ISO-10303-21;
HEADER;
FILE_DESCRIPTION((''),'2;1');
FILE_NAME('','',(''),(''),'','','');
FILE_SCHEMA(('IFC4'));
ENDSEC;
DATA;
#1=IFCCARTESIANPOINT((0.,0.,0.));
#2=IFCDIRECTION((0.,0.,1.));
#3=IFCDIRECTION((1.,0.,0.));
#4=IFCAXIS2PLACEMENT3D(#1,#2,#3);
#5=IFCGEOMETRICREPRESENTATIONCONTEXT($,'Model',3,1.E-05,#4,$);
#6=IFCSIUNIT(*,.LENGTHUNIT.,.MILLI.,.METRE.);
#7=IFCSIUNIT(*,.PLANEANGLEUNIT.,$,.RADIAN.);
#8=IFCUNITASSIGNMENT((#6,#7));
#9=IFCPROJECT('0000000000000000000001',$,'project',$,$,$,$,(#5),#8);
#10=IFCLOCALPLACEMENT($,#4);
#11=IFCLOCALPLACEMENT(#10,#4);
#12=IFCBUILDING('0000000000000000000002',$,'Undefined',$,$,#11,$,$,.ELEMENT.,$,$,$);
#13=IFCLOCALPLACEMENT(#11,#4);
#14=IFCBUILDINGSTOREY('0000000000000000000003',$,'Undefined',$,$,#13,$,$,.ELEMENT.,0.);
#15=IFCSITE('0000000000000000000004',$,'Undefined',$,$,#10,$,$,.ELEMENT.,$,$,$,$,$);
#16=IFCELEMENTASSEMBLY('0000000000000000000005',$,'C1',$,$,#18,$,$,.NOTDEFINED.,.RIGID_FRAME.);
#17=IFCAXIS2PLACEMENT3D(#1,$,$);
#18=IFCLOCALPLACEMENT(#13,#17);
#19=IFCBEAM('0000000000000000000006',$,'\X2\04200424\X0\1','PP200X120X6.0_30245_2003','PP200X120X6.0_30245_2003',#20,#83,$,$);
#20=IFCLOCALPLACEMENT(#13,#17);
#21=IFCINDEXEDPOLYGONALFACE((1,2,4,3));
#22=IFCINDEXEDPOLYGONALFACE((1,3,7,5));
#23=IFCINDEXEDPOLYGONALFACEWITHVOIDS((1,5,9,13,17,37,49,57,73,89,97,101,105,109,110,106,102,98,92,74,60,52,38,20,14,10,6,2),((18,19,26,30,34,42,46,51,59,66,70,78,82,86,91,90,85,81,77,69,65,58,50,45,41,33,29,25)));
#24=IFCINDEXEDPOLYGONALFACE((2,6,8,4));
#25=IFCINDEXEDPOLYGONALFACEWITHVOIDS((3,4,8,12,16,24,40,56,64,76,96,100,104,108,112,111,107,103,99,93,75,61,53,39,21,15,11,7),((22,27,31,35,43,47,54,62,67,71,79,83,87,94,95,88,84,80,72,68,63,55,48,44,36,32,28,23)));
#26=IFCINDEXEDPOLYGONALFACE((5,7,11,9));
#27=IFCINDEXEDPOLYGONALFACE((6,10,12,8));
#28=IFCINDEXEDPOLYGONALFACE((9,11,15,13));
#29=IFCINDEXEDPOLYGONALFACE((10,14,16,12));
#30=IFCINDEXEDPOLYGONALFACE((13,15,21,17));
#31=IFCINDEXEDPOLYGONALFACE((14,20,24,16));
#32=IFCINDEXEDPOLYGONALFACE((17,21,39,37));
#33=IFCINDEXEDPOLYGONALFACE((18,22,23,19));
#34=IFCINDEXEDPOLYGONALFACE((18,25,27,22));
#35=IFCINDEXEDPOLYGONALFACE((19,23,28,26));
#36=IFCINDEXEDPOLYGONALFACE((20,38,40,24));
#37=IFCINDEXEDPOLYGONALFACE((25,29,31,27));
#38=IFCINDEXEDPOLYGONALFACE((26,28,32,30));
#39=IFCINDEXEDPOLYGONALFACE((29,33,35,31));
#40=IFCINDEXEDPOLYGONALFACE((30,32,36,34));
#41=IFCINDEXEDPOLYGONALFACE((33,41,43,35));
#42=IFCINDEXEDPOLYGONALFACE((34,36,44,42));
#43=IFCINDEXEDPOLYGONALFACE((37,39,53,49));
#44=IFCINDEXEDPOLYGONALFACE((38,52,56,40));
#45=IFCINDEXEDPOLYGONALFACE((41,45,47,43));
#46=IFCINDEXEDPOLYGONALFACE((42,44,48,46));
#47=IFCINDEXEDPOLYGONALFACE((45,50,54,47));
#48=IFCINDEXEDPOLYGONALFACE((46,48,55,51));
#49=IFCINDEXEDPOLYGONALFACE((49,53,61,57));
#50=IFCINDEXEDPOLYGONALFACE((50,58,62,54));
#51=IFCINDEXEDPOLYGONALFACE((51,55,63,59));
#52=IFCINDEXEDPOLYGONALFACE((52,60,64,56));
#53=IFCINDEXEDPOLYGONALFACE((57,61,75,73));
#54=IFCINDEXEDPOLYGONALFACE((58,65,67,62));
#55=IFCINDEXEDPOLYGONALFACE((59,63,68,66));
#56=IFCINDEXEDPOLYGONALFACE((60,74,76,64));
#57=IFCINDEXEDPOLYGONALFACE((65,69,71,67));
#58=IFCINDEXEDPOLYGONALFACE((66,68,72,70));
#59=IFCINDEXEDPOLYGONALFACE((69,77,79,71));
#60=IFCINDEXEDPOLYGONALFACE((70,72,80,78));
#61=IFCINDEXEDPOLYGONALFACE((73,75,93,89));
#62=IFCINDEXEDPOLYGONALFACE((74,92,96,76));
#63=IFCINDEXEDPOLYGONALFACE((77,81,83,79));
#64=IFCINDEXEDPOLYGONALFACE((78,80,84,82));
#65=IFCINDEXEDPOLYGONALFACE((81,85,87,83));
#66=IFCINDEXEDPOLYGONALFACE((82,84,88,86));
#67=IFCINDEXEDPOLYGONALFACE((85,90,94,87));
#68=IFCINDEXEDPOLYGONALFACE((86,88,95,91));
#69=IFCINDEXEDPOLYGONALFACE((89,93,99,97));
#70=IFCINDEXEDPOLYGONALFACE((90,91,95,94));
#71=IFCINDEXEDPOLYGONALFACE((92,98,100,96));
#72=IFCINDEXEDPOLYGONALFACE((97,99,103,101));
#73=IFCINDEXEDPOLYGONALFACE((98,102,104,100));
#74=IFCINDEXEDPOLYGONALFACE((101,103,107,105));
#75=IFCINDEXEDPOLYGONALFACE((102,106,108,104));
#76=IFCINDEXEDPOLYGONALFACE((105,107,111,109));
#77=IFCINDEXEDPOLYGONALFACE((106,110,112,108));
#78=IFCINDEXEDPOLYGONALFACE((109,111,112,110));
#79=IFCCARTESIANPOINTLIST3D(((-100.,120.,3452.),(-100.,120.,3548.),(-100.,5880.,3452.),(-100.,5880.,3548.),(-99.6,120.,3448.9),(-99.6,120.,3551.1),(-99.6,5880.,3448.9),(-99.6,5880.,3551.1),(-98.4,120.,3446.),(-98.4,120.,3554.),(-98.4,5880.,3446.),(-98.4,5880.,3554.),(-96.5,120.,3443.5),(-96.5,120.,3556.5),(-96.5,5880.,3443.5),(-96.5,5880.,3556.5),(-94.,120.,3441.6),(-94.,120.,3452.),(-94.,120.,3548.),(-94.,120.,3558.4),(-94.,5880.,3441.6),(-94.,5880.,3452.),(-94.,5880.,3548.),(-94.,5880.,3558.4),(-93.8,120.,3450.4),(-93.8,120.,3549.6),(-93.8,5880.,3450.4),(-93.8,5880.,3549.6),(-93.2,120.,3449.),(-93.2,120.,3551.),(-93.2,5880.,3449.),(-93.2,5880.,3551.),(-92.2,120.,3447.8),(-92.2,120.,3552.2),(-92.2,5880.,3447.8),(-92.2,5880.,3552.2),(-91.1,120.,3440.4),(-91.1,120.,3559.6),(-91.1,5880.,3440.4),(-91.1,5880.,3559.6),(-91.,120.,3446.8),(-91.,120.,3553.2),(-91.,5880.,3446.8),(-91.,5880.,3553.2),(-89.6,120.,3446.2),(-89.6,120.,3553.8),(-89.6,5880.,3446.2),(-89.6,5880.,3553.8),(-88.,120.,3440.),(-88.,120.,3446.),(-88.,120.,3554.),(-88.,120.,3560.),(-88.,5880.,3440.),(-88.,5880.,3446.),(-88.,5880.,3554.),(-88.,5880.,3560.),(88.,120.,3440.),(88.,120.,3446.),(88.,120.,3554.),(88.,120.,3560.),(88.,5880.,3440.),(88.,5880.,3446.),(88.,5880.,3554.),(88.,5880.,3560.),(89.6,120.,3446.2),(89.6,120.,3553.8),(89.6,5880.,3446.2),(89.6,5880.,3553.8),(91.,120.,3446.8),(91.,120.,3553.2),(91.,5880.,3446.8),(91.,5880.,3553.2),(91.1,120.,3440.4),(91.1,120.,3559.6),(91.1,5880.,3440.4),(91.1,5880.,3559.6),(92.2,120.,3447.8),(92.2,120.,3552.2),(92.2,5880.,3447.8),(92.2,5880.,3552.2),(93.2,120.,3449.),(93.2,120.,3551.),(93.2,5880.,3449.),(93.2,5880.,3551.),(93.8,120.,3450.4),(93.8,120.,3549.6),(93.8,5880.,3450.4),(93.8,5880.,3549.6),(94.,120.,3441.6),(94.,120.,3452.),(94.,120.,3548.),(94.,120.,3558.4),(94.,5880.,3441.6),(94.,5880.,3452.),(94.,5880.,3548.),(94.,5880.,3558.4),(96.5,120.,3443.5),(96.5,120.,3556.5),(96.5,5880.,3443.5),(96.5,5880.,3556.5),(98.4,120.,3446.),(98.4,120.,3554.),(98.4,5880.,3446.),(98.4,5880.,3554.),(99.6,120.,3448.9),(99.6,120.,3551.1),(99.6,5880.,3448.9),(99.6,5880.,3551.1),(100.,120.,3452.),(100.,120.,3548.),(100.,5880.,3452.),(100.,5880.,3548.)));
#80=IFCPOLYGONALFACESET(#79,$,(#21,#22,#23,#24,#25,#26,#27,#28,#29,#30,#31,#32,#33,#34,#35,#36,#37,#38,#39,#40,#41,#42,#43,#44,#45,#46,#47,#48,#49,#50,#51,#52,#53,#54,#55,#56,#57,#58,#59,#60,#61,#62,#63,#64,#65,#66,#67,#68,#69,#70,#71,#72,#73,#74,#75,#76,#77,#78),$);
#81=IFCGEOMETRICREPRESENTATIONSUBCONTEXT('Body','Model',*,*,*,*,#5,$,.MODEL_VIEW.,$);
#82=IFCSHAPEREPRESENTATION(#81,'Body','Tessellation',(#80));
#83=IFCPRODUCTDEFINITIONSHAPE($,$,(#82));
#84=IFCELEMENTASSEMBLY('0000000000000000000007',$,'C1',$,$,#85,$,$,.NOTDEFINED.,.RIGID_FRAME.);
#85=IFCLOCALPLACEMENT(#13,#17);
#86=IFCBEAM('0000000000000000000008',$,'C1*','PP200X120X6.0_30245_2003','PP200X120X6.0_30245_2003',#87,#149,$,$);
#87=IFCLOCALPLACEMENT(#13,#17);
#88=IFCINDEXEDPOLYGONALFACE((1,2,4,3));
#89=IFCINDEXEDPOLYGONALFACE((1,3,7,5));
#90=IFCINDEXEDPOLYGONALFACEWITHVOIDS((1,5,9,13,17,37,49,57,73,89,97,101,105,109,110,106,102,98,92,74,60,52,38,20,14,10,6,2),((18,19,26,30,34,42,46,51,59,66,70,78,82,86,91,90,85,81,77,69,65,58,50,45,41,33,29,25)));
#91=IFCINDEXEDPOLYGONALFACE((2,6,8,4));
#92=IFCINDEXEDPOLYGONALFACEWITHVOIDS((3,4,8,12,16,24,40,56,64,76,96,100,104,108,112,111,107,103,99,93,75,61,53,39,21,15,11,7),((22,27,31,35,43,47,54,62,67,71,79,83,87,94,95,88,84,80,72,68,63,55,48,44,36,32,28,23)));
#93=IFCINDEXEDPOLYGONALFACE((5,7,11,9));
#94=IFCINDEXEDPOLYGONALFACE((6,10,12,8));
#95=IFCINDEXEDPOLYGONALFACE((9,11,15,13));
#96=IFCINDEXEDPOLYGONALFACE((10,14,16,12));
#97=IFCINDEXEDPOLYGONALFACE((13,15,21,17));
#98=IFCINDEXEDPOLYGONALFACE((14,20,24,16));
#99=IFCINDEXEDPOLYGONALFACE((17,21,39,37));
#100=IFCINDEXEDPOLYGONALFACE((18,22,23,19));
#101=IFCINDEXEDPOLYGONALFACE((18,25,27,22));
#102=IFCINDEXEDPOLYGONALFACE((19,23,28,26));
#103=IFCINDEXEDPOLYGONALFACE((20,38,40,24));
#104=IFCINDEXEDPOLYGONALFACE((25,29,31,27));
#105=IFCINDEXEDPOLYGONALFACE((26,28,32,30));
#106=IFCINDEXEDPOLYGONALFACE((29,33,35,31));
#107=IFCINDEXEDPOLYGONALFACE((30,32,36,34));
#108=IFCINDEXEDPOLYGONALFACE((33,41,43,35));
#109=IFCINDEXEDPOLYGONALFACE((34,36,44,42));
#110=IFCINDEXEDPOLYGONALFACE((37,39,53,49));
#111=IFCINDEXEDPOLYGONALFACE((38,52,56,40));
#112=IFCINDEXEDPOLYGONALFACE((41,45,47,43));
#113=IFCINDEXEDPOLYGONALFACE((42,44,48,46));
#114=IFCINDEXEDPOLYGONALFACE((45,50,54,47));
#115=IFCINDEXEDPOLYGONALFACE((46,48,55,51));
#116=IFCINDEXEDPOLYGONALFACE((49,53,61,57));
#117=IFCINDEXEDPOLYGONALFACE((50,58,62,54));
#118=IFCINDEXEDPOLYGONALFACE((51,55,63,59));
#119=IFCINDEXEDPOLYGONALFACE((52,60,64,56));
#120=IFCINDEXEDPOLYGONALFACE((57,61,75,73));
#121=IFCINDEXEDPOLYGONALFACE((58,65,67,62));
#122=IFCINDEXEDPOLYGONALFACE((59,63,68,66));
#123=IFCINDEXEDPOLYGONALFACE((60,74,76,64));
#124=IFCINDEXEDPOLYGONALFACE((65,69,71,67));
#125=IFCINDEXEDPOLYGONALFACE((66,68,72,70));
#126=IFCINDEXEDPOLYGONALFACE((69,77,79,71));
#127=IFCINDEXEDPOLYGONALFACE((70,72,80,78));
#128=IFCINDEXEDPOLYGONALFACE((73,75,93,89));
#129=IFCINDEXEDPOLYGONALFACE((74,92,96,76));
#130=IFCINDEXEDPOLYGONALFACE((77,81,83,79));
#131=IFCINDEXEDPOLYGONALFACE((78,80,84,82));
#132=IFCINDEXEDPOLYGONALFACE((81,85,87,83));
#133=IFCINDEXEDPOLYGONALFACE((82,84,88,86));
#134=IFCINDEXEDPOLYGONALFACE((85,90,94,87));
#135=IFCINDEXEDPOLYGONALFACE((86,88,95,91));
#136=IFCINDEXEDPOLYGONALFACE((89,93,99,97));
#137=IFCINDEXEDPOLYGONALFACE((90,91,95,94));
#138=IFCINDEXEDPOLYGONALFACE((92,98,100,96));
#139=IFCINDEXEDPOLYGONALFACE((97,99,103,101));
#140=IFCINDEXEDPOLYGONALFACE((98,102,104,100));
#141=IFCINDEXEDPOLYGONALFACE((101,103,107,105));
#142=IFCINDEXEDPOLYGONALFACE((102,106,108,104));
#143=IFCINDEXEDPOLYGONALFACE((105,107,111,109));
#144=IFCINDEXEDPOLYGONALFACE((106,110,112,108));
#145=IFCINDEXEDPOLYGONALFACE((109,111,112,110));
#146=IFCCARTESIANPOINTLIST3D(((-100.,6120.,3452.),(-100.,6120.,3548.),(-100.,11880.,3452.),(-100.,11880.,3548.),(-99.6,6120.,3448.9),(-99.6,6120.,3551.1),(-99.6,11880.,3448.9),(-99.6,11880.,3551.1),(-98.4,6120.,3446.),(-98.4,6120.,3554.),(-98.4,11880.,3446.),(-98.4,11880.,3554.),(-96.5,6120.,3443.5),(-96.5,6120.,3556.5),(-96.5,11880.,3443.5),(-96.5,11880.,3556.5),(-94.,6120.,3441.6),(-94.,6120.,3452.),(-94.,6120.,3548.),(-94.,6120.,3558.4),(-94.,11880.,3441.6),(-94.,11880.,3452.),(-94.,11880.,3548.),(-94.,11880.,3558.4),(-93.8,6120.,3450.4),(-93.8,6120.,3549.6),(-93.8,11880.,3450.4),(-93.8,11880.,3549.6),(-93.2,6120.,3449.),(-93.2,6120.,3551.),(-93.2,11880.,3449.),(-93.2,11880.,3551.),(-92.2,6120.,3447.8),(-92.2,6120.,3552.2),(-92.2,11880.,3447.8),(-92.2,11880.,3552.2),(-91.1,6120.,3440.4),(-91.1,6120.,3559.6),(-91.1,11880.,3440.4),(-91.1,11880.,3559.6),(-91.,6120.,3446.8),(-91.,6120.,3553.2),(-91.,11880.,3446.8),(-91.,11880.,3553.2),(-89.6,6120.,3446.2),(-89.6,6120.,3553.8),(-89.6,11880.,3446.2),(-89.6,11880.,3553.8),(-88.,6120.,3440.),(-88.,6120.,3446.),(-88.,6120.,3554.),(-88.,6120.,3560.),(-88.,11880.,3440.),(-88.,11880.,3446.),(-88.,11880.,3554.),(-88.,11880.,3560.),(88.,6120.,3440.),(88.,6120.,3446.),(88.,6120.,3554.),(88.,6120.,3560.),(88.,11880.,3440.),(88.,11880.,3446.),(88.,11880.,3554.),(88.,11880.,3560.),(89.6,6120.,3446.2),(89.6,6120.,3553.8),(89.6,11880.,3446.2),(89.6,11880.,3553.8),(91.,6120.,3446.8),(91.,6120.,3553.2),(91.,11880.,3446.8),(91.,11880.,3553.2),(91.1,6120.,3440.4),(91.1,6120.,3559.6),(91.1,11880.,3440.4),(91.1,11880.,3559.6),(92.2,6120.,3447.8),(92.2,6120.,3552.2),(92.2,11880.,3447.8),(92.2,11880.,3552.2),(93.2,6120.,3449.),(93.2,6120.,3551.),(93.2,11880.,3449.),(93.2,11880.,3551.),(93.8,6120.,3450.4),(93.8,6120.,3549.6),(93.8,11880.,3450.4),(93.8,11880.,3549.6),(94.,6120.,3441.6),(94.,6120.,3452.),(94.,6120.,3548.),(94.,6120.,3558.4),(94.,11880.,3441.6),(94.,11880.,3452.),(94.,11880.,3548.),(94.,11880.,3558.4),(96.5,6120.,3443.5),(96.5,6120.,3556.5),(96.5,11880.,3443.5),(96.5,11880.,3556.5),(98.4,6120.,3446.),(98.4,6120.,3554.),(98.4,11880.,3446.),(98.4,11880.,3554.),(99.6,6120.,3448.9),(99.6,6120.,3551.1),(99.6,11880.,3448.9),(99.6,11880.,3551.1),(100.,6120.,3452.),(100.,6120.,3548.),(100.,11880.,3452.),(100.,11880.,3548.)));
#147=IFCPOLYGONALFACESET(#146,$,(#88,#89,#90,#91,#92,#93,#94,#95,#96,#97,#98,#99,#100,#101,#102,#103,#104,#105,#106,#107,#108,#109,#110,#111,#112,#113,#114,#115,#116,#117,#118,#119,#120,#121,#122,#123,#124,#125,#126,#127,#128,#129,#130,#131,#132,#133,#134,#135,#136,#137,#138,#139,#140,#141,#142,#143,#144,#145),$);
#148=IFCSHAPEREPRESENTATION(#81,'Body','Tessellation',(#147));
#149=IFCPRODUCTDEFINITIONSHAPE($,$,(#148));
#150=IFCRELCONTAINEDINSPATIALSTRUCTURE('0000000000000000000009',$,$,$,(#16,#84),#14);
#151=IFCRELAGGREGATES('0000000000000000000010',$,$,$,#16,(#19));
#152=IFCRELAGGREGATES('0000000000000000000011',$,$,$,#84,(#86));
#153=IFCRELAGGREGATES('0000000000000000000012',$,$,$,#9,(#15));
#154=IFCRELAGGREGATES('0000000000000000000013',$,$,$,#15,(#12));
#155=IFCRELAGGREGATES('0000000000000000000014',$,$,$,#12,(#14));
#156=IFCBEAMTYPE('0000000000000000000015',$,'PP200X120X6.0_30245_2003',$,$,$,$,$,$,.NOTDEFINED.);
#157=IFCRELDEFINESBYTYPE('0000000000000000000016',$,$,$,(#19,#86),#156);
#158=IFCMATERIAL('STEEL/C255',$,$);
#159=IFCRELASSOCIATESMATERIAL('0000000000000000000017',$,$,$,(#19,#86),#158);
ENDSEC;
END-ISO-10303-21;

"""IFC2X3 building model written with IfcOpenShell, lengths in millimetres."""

from ifc_helpers import new_model, si_unit, frame, origin_with_axes, origin_2d_with_axis, place, context, subcontext, project, spatial, hollow_rectangle, extrude, material, type_object, element, aggregate, save


model = new_model("IFC2X3")

# Units and contexts
model_context = context("Model", 3, precision=1e-05, world=origin_with_axes())
body_context = subcontext(model_context, "Body", "Model", "MODEL_VIEW")
ifc_project = project(units=[si_unit("LENGTHUNIT", "METRE", prefix="MILLI"), si_unit("PLANEANGLEUNIT", "RADIAN")], contexts=[model_context])

# Site, building, storey
site_placement = place(None, origin_with_axes())
site = spatial("IfcSite", under=ifc_project, at=site_placement, Name="Undefined", CompositionType="ELEMENT")
building_placement = place(site_placement, origin_with_axes())
building = spatial("IfcBuilding", under=site, at=building_placement, Name="Undefined", CompositionType="ELEMENT")
storey_placement = place(building_placement, origin_with_axes())
storey = spatial("IfcBuildingStorey", under=building, at=storey_placement, Name="Undefined", CompositionType="ELEMENT", Elevation=0.0)

# Element assemblies, beams
ifc_material_1 = material(Name="STEEL/C255")
beam_type_1 = type_object("IfcBeamType", Name="PP200X120X6.0_30245_2003", PredefinedType="NOTDEFINED")
assembly_1_placement = place(storey_placement, origin_with_axes())
assembly_1 = element("IfcElementAssembly", 1, at=assembly_1_placement, inside=storey, Name="C1", AssemblyPlace="NOTDEFINED", PredefinedType="RIGID_FRAME")
beam_1_placement = place(assembly_1_placement, frame((0.0, 120.0, 3500.0), z_axis=(-1.0, 0.0, 0.0), x_axis=(0.0, 1.0, 0.0)))
beam_1 = element("IfcBeam", 2, at=beam_1_placement, type_object=beam_type_1, material=ifc_material_1, Name="РФ1", Description="PP200X120X6.0_30245_2003", ObjectType="PP200X120X6.0_30245_2003", context=body_context, shape_type="SweptSolid", body=[
    extrude(hollow_rectangle(XDim=120.0, YDim=200.0, WallThickness=6.0, InnerFilletRadius=6.0, OuterFilletRadius=12.0, at=origin_2d_with_axis()), frame((5760.0, 0.0, 0.0), z_axis=(-1.0, 0.0, 0.0), x_axis=(0.0, -1.0, 0.0)), (0.0, 0.0, 1.0), 5760.0),
])
aggregate(assembly_1, [beam_1])
assembly_2_placement = place(storey_placement, origin_with_axes())
assembly_2 = element("IfcElementAssembly", 3, at=assembly_2_placement, inside=storey, Name="C1", AssemblyPlace="NOTDEFINED", PredefinedType="RIGID_FRAME")
beam_2_placement = place(assembly_2_placement, frame((0.0, 6120.0, 3500.0), z_axis=(-1.0, 0.0, 0.0), x_axis=(0.0, 1.0, 0.0)))
beam_2 = element("IfcBeam", 4, at=beam_2_placement, type_object=beam_type_1, material=ifc_material_1, Name="C1*", Description="PP200X120X6.0_30245_2003", ObjectType="PP200X120X6.0_30245_2003", context=body_context, shape_type="SweptSolid", body=[
    extrude(hollow_rectangle(XDim=120.0, YDim=200.0, WallThickness=6.0, InnerFilletRadius=6.0, OuterFilletRadius=12.0, at=origin_2d_with_axis()), frame((5760.0, 0.0, 0.0), z_axis=(-1.0, 0.0, 0.0), x_axis=(0.0, -1.0, 0.0)), (0.0, 0.0, 1.0), 5760.0),
])
aggregate(assembly_2, [beam_2])

save(model, "model.ifc")
